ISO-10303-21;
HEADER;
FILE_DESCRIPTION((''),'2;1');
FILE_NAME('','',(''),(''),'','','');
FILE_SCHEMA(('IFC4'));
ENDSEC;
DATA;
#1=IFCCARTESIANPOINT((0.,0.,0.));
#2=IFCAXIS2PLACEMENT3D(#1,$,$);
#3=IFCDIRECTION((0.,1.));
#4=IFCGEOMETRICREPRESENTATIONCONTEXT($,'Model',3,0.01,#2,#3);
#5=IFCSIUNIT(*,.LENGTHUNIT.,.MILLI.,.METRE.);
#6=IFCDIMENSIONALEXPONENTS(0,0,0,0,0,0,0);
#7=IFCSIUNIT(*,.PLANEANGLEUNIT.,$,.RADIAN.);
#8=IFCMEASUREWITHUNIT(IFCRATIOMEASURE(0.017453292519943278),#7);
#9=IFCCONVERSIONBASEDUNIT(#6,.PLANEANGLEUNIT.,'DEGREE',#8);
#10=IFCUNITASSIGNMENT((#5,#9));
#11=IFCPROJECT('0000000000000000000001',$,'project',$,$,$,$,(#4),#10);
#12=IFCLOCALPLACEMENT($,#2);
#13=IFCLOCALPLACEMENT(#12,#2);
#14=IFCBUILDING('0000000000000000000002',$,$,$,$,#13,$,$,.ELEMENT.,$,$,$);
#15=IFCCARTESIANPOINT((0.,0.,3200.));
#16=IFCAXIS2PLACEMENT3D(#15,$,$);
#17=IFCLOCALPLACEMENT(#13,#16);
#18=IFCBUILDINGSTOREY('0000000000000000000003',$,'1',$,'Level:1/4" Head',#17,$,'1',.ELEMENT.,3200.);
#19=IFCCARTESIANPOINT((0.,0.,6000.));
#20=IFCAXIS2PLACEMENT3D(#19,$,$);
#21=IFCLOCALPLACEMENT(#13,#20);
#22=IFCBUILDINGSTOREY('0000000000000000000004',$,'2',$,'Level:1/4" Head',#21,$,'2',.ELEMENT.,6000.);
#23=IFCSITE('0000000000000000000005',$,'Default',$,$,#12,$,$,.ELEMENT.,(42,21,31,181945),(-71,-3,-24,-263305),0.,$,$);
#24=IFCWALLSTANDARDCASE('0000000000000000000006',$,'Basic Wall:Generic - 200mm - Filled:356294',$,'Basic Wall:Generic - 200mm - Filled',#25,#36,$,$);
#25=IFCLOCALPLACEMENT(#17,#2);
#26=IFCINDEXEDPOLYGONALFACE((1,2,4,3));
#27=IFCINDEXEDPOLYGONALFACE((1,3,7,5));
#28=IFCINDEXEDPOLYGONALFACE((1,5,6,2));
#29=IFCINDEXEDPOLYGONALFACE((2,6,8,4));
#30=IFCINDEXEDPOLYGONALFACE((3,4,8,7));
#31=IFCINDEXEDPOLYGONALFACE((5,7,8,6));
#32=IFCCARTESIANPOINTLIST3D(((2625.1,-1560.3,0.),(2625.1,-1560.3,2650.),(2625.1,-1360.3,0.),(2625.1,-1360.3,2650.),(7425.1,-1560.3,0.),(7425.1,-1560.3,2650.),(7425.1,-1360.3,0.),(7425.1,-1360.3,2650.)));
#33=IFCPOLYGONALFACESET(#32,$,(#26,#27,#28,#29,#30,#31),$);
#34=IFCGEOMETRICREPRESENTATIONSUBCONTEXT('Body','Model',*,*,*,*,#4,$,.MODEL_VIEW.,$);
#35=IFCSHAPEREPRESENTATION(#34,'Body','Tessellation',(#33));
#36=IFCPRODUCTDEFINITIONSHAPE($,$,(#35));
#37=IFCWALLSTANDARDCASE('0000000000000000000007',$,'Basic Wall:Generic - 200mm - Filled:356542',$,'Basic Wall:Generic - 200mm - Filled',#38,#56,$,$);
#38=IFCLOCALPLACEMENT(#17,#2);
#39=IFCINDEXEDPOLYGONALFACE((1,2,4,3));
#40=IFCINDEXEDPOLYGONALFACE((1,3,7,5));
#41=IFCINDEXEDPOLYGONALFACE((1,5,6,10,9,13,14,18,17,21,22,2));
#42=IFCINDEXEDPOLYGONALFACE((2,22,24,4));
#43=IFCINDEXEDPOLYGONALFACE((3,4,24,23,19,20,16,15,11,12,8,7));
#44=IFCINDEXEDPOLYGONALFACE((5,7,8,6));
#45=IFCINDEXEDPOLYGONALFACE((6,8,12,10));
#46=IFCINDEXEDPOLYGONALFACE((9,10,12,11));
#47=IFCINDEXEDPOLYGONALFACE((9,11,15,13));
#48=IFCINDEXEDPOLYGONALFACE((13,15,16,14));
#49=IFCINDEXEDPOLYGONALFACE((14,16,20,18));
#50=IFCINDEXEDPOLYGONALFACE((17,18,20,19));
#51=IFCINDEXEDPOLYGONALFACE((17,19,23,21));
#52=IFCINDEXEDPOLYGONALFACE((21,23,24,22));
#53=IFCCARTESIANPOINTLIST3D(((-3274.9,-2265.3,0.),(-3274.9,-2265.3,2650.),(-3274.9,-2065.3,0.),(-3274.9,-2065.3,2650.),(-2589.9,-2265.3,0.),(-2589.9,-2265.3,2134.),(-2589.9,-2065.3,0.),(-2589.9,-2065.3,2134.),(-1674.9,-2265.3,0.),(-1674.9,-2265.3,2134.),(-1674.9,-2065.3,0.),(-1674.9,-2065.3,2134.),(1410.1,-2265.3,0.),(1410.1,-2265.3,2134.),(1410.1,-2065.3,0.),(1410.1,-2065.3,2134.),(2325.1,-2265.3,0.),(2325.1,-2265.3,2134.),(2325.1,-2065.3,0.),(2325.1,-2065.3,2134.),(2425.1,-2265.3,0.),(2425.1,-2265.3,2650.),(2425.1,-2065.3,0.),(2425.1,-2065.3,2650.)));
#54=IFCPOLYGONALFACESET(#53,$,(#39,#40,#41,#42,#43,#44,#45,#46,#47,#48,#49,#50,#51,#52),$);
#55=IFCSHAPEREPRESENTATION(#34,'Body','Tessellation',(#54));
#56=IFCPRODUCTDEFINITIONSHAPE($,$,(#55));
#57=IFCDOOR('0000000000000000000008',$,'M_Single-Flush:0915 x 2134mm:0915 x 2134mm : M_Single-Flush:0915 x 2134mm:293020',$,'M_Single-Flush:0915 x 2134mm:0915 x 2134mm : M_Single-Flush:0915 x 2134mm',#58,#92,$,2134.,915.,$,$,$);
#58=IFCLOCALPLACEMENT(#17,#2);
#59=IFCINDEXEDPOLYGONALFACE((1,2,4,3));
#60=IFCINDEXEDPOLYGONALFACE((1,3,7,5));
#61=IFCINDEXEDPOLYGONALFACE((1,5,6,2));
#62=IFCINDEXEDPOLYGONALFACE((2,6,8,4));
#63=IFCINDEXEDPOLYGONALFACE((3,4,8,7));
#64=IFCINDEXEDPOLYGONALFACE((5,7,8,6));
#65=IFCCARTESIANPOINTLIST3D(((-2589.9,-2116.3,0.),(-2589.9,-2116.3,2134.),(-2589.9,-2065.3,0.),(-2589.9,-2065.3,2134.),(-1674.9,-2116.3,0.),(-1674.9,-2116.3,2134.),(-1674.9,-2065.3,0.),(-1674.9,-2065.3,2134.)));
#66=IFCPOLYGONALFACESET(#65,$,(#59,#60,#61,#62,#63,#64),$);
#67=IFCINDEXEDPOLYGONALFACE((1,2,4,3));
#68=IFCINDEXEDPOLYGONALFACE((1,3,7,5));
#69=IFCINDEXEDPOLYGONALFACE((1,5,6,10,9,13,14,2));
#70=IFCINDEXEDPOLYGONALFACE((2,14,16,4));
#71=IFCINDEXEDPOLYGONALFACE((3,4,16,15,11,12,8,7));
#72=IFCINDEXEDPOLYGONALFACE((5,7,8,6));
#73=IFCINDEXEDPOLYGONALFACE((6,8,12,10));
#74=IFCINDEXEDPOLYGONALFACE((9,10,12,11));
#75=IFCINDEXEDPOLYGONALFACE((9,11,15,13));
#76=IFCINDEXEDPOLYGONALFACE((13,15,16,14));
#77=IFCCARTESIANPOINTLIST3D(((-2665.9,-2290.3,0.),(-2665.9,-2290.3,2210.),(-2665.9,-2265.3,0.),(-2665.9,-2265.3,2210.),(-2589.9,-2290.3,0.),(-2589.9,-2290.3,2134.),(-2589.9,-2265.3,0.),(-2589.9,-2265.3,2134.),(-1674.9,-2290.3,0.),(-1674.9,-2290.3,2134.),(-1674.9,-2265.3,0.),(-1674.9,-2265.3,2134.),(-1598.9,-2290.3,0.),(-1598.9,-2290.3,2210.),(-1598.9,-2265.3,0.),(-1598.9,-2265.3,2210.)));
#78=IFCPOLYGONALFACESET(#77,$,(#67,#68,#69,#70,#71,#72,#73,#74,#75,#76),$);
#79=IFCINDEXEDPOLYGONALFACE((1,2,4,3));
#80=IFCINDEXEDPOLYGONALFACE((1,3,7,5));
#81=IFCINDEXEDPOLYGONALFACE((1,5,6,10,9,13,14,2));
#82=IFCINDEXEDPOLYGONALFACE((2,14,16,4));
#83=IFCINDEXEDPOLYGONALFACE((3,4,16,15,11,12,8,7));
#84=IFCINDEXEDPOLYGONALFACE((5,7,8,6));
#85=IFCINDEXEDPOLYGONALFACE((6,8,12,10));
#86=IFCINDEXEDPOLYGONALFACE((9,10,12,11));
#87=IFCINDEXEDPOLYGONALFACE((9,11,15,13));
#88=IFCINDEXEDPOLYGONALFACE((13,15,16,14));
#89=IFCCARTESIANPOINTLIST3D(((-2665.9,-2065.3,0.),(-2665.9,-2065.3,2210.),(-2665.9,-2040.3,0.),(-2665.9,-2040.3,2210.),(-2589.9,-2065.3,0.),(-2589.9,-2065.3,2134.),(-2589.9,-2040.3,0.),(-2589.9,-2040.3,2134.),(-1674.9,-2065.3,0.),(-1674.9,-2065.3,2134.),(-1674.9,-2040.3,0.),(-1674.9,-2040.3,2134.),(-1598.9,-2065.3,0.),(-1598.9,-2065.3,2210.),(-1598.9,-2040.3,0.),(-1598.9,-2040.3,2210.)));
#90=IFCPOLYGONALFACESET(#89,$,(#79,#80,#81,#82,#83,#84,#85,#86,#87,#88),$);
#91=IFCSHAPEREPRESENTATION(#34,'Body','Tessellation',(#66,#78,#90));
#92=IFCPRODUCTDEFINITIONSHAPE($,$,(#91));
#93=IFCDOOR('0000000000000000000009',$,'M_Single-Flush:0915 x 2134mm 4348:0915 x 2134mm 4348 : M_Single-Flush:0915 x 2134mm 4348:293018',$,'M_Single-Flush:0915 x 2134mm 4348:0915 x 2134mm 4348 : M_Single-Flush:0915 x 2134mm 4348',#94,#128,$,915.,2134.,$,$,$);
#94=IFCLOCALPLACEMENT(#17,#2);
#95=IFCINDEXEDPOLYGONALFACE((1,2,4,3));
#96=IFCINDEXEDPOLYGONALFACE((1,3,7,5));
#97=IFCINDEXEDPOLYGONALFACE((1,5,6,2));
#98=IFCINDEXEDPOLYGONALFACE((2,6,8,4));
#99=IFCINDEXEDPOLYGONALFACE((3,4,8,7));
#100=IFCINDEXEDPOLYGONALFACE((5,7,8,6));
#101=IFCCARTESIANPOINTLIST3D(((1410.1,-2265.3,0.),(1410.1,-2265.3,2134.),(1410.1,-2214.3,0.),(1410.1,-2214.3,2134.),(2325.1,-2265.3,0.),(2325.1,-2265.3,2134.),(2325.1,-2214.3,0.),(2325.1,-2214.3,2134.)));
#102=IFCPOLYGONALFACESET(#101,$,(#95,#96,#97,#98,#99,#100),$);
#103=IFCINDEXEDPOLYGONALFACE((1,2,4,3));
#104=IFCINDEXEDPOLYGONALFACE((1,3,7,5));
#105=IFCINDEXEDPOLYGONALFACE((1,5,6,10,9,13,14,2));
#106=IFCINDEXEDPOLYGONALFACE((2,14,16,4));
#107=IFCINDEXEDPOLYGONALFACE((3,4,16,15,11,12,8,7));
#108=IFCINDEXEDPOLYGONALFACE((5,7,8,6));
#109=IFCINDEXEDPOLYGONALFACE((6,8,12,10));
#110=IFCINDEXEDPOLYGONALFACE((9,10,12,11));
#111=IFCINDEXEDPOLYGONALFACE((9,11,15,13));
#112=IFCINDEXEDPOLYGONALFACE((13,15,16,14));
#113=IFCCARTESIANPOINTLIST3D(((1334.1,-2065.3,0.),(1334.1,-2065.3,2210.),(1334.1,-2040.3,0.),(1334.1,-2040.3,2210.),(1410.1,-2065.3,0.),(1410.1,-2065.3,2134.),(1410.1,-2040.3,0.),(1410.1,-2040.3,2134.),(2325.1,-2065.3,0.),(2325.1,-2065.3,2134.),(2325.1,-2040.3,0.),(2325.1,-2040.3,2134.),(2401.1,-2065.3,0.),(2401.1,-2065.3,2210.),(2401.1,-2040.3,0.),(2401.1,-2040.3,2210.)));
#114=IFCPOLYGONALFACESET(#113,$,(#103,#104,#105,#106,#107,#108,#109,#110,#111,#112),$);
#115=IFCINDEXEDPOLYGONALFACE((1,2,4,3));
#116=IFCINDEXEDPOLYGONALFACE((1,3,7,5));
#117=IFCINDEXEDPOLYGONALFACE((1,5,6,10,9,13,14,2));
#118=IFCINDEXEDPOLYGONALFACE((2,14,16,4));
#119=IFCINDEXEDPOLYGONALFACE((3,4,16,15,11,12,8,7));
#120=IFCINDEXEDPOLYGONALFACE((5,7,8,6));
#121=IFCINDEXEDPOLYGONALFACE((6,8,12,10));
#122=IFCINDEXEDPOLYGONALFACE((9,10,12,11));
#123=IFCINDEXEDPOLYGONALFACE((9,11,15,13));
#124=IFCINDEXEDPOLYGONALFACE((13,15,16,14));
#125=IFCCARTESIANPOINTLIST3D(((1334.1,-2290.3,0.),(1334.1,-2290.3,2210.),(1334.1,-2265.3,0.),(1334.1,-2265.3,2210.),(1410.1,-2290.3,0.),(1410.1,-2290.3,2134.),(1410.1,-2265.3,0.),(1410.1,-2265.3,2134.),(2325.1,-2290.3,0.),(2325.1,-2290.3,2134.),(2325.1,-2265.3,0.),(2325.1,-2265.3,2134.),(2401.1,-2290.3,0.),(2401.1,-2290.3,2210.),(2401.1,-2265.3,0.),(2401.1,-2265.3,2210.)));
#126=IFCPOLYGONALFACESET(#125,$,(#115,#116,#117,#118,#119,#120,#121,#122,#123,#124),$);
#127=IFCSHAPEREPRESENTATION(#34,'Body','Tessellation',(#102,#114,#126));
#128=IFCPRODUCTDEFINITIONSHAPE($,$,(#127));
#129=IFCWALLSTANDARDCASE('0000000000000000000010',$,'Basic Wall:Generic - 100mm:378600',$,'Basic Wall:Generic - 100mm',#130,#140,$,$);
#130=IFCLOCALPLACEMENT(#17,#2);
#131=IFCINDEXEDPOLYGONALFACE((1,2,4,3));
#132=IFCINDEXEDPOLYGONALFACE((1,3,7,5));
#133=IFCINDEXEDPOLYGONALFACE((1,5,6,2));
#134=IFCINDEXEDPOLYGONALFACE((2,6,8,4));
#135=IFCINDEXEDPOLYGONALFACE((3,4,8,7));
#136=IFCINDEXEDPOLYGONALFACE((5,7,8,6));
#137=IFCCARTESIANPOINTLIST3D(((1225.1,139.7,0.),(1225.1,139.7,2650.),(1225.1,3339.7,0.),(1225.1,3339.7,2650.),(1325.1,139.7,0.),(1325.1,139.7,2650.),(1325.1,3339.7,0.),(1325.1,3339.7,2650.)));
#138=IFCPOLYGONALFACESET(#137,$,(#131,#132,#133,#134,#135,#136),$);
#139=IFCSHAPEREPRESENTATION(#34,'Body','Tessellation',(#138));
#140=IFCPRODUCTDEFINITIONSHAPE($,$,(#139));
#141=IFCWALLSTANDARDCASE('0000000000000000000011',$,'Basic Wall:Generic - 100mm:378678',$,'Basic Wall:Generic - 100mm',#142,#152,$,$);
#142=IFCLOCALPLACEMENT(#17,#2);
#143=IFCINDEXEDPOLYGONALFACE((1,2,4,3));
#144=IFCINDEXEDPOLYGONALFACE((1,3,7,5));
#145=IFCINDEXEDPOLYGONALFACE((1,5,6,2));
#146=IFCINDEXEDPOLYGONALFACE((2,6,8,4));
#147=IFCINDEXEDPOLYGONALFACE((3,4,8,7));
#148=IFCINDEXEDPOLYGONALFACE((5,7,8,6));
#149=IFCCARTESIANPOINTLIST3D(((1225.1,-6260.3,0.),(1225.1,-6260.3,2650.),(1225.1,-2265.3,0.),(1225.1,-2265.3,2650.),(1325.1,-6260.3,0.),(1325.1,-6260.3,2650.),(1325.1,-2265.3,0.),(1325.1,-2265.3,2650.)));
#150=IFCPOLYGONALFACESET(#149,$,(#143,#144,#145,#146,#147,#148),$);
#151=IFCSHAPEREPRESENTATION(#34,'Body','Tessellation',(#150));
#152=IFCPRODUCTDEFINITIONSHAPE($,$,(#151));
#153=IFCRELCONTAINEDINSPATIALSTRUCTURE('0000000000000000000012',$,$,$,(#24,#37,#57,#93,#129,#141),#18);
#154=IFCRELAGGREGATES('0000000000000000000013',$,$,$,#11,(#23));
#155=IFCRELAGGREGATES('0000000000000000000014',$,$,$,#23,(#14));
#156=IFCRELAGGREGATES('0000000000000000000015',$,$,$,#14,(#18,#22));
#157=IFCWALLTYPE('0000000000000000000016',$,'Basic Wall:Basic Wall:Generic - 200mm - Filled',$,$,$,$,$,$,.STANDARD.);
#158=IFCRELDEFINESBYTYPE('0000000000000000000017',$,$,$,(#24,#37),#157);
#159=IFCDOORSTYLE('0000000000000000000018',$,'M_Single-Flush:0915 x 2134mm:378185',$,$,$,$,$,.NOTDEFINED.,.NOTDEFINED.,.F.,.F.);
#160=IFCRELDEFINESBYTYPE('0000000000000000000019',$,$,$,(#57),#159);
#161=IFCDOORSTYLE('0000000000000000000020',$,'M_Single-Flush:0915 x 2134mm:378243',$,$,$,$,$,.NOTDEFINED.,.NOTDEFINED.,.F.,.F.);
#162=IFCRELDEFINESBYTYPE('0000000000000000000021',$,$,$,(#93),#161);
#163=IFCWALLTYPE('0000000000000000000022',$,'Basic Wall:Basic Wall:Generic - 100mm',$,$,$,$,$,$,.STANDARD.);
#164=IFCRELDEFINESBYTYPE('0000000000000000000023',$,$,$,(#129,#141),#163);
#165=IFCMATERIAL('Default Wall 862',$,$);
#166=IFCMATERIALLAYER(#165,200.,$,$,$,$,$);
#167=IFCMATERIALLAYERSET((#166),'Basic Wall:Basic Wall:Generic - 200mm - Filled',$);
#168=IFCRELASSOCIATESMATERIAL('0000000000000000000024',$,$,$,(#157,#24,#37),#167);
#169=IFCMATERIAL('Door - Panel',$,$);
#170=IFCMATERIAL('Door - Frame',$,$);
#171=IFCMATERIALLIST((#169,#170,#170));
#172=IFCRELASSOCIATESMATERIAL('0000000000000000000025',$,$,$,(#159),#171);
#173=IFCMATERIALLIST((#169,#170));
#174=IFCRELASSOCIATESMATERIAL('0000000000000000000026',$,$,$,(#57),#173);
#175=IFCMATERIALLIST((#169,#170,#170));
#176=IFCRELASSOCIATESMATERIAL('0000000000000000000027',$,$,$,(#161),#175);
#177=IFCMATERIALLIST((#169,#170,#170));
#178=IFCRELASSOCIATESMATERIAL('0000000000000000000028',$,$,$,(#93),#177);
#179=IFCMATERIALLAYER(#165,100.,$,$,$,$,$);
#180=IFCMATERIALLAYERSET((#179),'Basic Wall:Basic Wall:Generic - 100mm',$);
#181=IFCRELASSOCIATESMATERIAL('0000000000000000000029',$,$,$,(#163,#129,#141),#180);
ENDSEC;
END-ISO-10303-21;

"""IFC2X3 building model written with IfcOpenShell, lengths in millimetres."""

from ifc_helpers import new_model, entity, si_unit, converted_unit, direction, frame, frame_2d, origin, origin_2d_with_axis, place, context, subcontext, project, spatial, polyline, rectangle, outline, extrude, source, transform, mapped, material, material_list, layer, layer_set, layer_usage, type_object, type_shapes, element, fill, save


model = new_model("IFC2X3")

# Units and contexts
model_context = context("Model", 3, precision=0.01, world=origin(), true_north=direction((0.0, 1.0)))
body_context = subcontext(model_context, "Body", "Model", "MODEL_VIEW")
ifc_project = project(units=[si_unit("LENGTHUNIT", "METRE", prefix="MILLI"), converted_unit("PLANEANGLEUNIT", "DEGREE", entity("IfcRatioMeasure", 0.017453292519943278), si_unit("PLANEANGLEUNIT", "RADIAN"), dimensions=[0, 0, 0, 0, 0, 0, 0])], contexts=[model_context])

# Site, building, storey
site_placement = place(None, origin())
site = spatial("IfcSite", under=ifc_project, at=site_placement, Name="Default", CompositionType="ELEMENT", RefLatitude=(42, 21, 31, 181945), RefLongitude=(-71, -3, -24, -263305), RefElevation=0.0)
building_placement = place(site_placement, origin())
building = spatial("IfcBuilding", under=site, at=building_placement, CompositionType="ELEMENT")
storey_1_placement = place(building_placement, frame((0.0, 0.0, 3200.0)))
storey_1 = spatial("IfcBuildingStorey", under=building, at=storey_1_placement, Name="1", ObjectType="Level:1/4\" Head", LongName="1", CompositionType="ELEMENT", Elevation=3200.0)

# Shared definitions
ifc_material_1 = material(Name="Default Wall 862")

# Shared definitions
storey_2_placement = place(building_placement, frame((0.0, 0.0, 6000.0)))
storey_2 = spatial("IfcBuildingStorey", under=building, at=storey_2_placement, Name="2", ObjectType="Level:1/4\" Head", LongName="2", CompositionType="ELEMENT", Elevation=6000.0)

# Wall
ifc_layer_1 = layer(ifc_material_1, 200.0)
ifc_layer_set_1 = layer_set([ifc_layer_1], Name="Basic Wall:Basic Wall:Generic - 200mm - Filled")
ifc_layer_usage_1 = layer_usage(ifc_layer_set_1, "AXIS2", "NEGATIVE", 100.0)
wall_type_1 = type_object("IfcWallType", Name="Basic Wall:Basic Wall:Generic - 200mm - Filled", PredefinedType="STANDARD", material=ifc_layer_set_1)
wall_1_placement = place(storey_1_placement, frame((2625.1, -1460.3, 0.0)))
element("IfcWallStandardCase", 1, at=wall_1_placement, inside=storey_1, type_object=wall_type_1, material=ifc_layer_usage_1, Name="Basic Wall:Generic - 200mm - Filled:356294", ObjectType="Basic Wall:Generic - 200mm - Filled", context=body_context, shape_type="SweptSolid", body=[
    extrude(rectangle(XDim=4800.0, YDim=200.0, at=frame_2d((2400.0, 0.0), x_axis=(-1.0, 0.0))), origin(), (0.0, 0.0, 1.0), 2650.0),
])

# Wall, openings, doors
ifc_layer_usage_2 = layer_usage(ifc_layer_set_1, "AXIS2", "NEGATIVE", 100.0)
wall_2_placement = place(storey_1_placement, frame((2425.1, -2165.3, 0.0), z_axis=(0.0, 0.0, 1.0), x_axis=(-1.0, 0.0, 0.0)))
wall_2 = element("IfcWallStandardCase", 2, at=wall_2_placement, inside=storey_1, type_object=wall_type_1, material=ifc_layer_usage_2, Name="Basic Wall:Generic - 200mm - Filled:356542", ObjectType="Basic Wall:Generic - 200mm - Filled", context=body_context, shape_type="SweptSolid", body=[
    extrude(rectangle(XDim=5700.0, YDim=200.0, at=frame_2d((2850.0, 0.0), x_axis=(-1.0, 0.0))), origin(), (0.0, 0.0, 1.0), 2650.0),
])
opening_1_placement = place(wall_2_placement, frame((2425.1, -2165.3, 0.0), z_axis=(0.0, 0.0, 1.0), x_axis=(-1.0, 0.0, 0.0)))
opening_1 = element("IfcOpeningElement", 3, at=opening_1_placement, cuts=wall_2, ObjectType="Opening", context=body_context, shape_type="SweptSolid", body=[
    extrude(rectangle(XDim=2134.0, YDim=915.0, at=frame_2d((0.0, 0.0), x_axis=(0.0, 1.0))), frame((-2132.4, -2063.3, 1067.0), z_axis=(0.0, -1.0, 0.0), x_axis=(1.0, 0.0, 0.0)), (0.0, 0.0, 1.0), 204.0),
])
opening_2_placement = place(wall_2_placement, frame((2425.1, -2165.3, 0.0), z_axis=(0.0, 0.0, 1.0), x_axis=(-1.0, 0.0, 0.0)))
opening_2 = element("IfcOpeningElement", 4, at=opening_2_placement, cuts=wall_2, ObjectType="Opening", context=body_context, shape_type="SweptSolid", body=[
    extrude(rectangle(XDim=2134.0, YDim=915.0, at=frame_2d((0.0, 0.0), x_axis=(1.0, 0.0))), frame((1867.6, -2063.3, 1067.0), z_axis=(0.0, -1.0, 0.0), x_axis=(0.0, 0.0, -1.0)), (0.0, 0.0, 1.0), 204.0),
])
ifc_material_2 = material(Name="Door - Panel")
ifc_material_3 = material(Name="Door - Frame")
ifc_material_list_1 = material_list([ifc_material_2, ifc_material_3])
ifc_material_list_2 = material_list([ifc_material_2, ifc_material_3, ifc_material_3])
door_style_1 = type_object("IfcDoorStyle", Name="M_Single-Flush:0915 x 2134mm:378185", ConstructionType="NOTDEFINED", OperationType="NOTDEFINED", ParameterTakesPrecedence=False, Sizeable=False, material=ifc_material_list_2)
shared_shape_1 = source(origin(), body_context, "Body", "SweptSolid", [
    extrude(rectangle(XDim=51.0, YDim=915.0, at=origin_2d_with_axis()), frame((457.5, 176.5, 0.0), z_axis=(0.0, 0.0, 1.0), x_axis=(0.0, 1.0, 0.0)), (0.0, 0.0, 1.0), 2134.0),
    extrude(outline(polyline([(-1086.0, -533.5), (1124.0, -533.5), (1124.0, 533.5), (-1086.0, 533.5), (-1086.0, 457.5), (1048.0, 457.5), (1048.0, -457.5), (-1086.0, -457.5), (-1086.0, -533.5)])), frame((457.5, -23.0, 1086.0), z_axis=(0.0, 1.0, 0.0), x_axis=(0.0, 0.0, 1.0)), (0.0, 0.0, 1.0), 25.0),
    extrude(outline(polyline([(-533.5, -1124.0), (533.5, -1124.0), (533.5, 1086.0), (457.5, 1086.0), (457.5, -1048.0), (-457.5, -1048.0), (-457.5, 1086.0), (-533.5, 1086.0), (-533.5, -1124.0)])), frame((457.5, 202.0, 1086.0), z_axis=(0.0, 1.0, 0.0), x_axis=(1.0, 0.0, 0.0)), (0.0, 0.0, 1.0), 25.0),
])
type_shapes(door_style_1, [shared_shape_1])
door_1_placement = place(opening_1_placement, frame((-2589.9, -2267.3, 0.0)))
door_1 = element("IfcDoor", 5, at=door_1_placement, inside=storey_1, type_object=door_style_1, material=ifc_material_list_1, Name="M_Single-Flush:0915 x 2134mm:0915 x 2134mm : M_Single-Flush:0915 x 2134mm:293020", ObjectType="M_Single-Flush:0915 x 2134mm:0915 x 2134mm : M_Single-Flush:0915 x 2134mm", OverallHeight=2134.0, OverallWidth=915.0, context=body_context, shape_type="MappedRepresentation", body=[
    mapped(shared_shape_1, transform((0.0, 0.0, 0.0), scale=1.0)),
])
fill(opening_1, door_1)
ifc_material_list_3 = material_list([ifc_material_2, ifc_material_3, ifc_material_3])
ifc_material_list_4 = material_list([ifc_material_2, ifc_material_3, ifc_material_3])
door_style_2 = type_object("IfcDoorStyle", Name="M_Single-Flush:0915 x 2134mm:378243", ConstructionType="NOTDEFINED", OperationType="NOTDEFINED", ParameterTakesPrecedence=False, Sizeable=False, material=ifc_material_list_4)
shared_shape_2 = source(origin(), body_context, "Body", "SweptSolid", [
    extrude(rectangle(XDim=915.0, YDim=51.0, at=origin_2d_with_axis()), frame((457.5, -27.5, 0.0), z_axis=(0.0, 0.0, 1.0), x_axis=(-1.0, 0.0, 0.0)), (0.0, 0.0, 1.0), 2134.0),
    extrude(outline(polyline([(-533.5, -1086.0), (-457.5, -1086.0), (-457.5, 1048.0), (457.5, 1048.0), (457.5, -1086.0), (533.5, -1086.0), (533.5, 1124.0), (-533.5, 1124.0), (-533.5, -1086.0)])), frame((457.5, -227.0, 1086.0), z_axis=(0.0, 1.0, 0.0), x_axis=(-1.0, 0.0, 0.0)), (0.0, 0.0, 1.0), 25.0),
    extrude(outline(polyline([(-1124.0, -533.5), (1086.0, -533.5), (1086.0, -457.5), (-1048.0, -457.5), (-1048.0, 457.5), (1086.0, 457.5), (1086.0, 533.5), (-1124.0, 533.5), (-1124.0, -533.5)])), frame((457.5, -2.0, 1086.0), z_axis=(0.0, 1.0, 0.0), x_axis=(0.0, 0.0, -1.0)), (0.0, 0.0, 1.0), 25.0),
])
type_shapes(door_style_2, [shared_shape_2])
door_2_placement = place(opening_2_placement, frame((2325.1, -2267.3, 0.0), z_axis=(0.0, 0.0, 1.0), x_axis=(-1.0, 0.0, 0.0)))
door_2 = element("IfcDoor", 6, at=door_2_placement, inside=storey_1, type_object=door_style_2, material=ifc_material_list_3, Name="M_Single-Flush:0915 x 2134mm 4348:0915 x 2134mm 4348 : M_Single-Flush:0915 x 2134mm 4348:293018", ObjectType="M_Single-Flush:0915 x 2134mm 4348:0915 x 2134mm 4348 : M_Single-Flush:0915 x 2134mm 4348", OverallHeight=915.0, OverallWidth=2134.0, context=body_context, shape_type="MappedRepresentation", body=[
    mapped(shared_shape_2, transform((0.0, 0.0, 0.0), scale=1.0)),
])
fill(opening_2, door_2)

# Walls
ifc_layer_2 = layer(ifc_material_1, 100.0)
ifc_layer_set_2 = layer_set([ifc_layer_2], Name="Basic Wall:Basic Wall:Generic - 100mm")
ifc_layer_usage_3 = layer_usage(ifc_layer_set_2, "AXIS2", "NEGATIVE", 50.0)
wall_type_2 = type_object("IfcWallType", Name="Basic Wall:Basic Wall:Generic - 100mm", PredefinedType="STANDARD", material=ifc_layer_set_2)
wall_3_placement = place(storey_1_placement, frame((1275.1, 139.7, 0.0), z_axis=(0.0, 0.0, 1.0), x_axis=(0.0, 1.0, 0.0)))
element("IfcWallStandardCase", 7, at=wall_3_placement, inside=storey_1, type_object=wall_type_2, material=ifc_layer_usage_3, Name="Basic Wall:Generic - 100mm:378600", ObjectType="Basic Wall:Generic - 100mm", context=body_context, shape_type="SweptSolid", body=[
    extrude(rectangle(XDim=3200.0, YDim=100.0, at=frame_2d((1600.0, 0.0), x_axis=(-1.0, 0.0))), origin(), (0.0, 0.0, 1.0), 2650.0),
])
ifc_layer_usage_4 = layer_usage(ifc_layer_set_2, "AXIS2", "NEGATIVE", 50.0)
wall_4_placement = place(storey_1_placement, frame((1275.1, -2265.3, 0.0), z_axis=(0.0, 0.0, 1.0), x_axis=(0.0, -1.0, 0.0)))
element("IfcWallStandardCase", 8, at=wall_4_placement, inside=storey_1, type_object=wall_type_2, material=ifc_layer_usage_4, Name="Basic Wall:Generic - 100mm:378678", ObjectType="Basic Wall:Generic - 100mm", context=body_context, shape_type="SweptSolid", body=[
    extrude(rectangle(XDim=3995.0, YDim=100.0, at=frame_2d((1997.5, 0.0), x_axis=(-1.0, 0.0))), origin(), (0.0, 0.0, 1.0), 2650.0),
])

save(model, "model.ifc")
